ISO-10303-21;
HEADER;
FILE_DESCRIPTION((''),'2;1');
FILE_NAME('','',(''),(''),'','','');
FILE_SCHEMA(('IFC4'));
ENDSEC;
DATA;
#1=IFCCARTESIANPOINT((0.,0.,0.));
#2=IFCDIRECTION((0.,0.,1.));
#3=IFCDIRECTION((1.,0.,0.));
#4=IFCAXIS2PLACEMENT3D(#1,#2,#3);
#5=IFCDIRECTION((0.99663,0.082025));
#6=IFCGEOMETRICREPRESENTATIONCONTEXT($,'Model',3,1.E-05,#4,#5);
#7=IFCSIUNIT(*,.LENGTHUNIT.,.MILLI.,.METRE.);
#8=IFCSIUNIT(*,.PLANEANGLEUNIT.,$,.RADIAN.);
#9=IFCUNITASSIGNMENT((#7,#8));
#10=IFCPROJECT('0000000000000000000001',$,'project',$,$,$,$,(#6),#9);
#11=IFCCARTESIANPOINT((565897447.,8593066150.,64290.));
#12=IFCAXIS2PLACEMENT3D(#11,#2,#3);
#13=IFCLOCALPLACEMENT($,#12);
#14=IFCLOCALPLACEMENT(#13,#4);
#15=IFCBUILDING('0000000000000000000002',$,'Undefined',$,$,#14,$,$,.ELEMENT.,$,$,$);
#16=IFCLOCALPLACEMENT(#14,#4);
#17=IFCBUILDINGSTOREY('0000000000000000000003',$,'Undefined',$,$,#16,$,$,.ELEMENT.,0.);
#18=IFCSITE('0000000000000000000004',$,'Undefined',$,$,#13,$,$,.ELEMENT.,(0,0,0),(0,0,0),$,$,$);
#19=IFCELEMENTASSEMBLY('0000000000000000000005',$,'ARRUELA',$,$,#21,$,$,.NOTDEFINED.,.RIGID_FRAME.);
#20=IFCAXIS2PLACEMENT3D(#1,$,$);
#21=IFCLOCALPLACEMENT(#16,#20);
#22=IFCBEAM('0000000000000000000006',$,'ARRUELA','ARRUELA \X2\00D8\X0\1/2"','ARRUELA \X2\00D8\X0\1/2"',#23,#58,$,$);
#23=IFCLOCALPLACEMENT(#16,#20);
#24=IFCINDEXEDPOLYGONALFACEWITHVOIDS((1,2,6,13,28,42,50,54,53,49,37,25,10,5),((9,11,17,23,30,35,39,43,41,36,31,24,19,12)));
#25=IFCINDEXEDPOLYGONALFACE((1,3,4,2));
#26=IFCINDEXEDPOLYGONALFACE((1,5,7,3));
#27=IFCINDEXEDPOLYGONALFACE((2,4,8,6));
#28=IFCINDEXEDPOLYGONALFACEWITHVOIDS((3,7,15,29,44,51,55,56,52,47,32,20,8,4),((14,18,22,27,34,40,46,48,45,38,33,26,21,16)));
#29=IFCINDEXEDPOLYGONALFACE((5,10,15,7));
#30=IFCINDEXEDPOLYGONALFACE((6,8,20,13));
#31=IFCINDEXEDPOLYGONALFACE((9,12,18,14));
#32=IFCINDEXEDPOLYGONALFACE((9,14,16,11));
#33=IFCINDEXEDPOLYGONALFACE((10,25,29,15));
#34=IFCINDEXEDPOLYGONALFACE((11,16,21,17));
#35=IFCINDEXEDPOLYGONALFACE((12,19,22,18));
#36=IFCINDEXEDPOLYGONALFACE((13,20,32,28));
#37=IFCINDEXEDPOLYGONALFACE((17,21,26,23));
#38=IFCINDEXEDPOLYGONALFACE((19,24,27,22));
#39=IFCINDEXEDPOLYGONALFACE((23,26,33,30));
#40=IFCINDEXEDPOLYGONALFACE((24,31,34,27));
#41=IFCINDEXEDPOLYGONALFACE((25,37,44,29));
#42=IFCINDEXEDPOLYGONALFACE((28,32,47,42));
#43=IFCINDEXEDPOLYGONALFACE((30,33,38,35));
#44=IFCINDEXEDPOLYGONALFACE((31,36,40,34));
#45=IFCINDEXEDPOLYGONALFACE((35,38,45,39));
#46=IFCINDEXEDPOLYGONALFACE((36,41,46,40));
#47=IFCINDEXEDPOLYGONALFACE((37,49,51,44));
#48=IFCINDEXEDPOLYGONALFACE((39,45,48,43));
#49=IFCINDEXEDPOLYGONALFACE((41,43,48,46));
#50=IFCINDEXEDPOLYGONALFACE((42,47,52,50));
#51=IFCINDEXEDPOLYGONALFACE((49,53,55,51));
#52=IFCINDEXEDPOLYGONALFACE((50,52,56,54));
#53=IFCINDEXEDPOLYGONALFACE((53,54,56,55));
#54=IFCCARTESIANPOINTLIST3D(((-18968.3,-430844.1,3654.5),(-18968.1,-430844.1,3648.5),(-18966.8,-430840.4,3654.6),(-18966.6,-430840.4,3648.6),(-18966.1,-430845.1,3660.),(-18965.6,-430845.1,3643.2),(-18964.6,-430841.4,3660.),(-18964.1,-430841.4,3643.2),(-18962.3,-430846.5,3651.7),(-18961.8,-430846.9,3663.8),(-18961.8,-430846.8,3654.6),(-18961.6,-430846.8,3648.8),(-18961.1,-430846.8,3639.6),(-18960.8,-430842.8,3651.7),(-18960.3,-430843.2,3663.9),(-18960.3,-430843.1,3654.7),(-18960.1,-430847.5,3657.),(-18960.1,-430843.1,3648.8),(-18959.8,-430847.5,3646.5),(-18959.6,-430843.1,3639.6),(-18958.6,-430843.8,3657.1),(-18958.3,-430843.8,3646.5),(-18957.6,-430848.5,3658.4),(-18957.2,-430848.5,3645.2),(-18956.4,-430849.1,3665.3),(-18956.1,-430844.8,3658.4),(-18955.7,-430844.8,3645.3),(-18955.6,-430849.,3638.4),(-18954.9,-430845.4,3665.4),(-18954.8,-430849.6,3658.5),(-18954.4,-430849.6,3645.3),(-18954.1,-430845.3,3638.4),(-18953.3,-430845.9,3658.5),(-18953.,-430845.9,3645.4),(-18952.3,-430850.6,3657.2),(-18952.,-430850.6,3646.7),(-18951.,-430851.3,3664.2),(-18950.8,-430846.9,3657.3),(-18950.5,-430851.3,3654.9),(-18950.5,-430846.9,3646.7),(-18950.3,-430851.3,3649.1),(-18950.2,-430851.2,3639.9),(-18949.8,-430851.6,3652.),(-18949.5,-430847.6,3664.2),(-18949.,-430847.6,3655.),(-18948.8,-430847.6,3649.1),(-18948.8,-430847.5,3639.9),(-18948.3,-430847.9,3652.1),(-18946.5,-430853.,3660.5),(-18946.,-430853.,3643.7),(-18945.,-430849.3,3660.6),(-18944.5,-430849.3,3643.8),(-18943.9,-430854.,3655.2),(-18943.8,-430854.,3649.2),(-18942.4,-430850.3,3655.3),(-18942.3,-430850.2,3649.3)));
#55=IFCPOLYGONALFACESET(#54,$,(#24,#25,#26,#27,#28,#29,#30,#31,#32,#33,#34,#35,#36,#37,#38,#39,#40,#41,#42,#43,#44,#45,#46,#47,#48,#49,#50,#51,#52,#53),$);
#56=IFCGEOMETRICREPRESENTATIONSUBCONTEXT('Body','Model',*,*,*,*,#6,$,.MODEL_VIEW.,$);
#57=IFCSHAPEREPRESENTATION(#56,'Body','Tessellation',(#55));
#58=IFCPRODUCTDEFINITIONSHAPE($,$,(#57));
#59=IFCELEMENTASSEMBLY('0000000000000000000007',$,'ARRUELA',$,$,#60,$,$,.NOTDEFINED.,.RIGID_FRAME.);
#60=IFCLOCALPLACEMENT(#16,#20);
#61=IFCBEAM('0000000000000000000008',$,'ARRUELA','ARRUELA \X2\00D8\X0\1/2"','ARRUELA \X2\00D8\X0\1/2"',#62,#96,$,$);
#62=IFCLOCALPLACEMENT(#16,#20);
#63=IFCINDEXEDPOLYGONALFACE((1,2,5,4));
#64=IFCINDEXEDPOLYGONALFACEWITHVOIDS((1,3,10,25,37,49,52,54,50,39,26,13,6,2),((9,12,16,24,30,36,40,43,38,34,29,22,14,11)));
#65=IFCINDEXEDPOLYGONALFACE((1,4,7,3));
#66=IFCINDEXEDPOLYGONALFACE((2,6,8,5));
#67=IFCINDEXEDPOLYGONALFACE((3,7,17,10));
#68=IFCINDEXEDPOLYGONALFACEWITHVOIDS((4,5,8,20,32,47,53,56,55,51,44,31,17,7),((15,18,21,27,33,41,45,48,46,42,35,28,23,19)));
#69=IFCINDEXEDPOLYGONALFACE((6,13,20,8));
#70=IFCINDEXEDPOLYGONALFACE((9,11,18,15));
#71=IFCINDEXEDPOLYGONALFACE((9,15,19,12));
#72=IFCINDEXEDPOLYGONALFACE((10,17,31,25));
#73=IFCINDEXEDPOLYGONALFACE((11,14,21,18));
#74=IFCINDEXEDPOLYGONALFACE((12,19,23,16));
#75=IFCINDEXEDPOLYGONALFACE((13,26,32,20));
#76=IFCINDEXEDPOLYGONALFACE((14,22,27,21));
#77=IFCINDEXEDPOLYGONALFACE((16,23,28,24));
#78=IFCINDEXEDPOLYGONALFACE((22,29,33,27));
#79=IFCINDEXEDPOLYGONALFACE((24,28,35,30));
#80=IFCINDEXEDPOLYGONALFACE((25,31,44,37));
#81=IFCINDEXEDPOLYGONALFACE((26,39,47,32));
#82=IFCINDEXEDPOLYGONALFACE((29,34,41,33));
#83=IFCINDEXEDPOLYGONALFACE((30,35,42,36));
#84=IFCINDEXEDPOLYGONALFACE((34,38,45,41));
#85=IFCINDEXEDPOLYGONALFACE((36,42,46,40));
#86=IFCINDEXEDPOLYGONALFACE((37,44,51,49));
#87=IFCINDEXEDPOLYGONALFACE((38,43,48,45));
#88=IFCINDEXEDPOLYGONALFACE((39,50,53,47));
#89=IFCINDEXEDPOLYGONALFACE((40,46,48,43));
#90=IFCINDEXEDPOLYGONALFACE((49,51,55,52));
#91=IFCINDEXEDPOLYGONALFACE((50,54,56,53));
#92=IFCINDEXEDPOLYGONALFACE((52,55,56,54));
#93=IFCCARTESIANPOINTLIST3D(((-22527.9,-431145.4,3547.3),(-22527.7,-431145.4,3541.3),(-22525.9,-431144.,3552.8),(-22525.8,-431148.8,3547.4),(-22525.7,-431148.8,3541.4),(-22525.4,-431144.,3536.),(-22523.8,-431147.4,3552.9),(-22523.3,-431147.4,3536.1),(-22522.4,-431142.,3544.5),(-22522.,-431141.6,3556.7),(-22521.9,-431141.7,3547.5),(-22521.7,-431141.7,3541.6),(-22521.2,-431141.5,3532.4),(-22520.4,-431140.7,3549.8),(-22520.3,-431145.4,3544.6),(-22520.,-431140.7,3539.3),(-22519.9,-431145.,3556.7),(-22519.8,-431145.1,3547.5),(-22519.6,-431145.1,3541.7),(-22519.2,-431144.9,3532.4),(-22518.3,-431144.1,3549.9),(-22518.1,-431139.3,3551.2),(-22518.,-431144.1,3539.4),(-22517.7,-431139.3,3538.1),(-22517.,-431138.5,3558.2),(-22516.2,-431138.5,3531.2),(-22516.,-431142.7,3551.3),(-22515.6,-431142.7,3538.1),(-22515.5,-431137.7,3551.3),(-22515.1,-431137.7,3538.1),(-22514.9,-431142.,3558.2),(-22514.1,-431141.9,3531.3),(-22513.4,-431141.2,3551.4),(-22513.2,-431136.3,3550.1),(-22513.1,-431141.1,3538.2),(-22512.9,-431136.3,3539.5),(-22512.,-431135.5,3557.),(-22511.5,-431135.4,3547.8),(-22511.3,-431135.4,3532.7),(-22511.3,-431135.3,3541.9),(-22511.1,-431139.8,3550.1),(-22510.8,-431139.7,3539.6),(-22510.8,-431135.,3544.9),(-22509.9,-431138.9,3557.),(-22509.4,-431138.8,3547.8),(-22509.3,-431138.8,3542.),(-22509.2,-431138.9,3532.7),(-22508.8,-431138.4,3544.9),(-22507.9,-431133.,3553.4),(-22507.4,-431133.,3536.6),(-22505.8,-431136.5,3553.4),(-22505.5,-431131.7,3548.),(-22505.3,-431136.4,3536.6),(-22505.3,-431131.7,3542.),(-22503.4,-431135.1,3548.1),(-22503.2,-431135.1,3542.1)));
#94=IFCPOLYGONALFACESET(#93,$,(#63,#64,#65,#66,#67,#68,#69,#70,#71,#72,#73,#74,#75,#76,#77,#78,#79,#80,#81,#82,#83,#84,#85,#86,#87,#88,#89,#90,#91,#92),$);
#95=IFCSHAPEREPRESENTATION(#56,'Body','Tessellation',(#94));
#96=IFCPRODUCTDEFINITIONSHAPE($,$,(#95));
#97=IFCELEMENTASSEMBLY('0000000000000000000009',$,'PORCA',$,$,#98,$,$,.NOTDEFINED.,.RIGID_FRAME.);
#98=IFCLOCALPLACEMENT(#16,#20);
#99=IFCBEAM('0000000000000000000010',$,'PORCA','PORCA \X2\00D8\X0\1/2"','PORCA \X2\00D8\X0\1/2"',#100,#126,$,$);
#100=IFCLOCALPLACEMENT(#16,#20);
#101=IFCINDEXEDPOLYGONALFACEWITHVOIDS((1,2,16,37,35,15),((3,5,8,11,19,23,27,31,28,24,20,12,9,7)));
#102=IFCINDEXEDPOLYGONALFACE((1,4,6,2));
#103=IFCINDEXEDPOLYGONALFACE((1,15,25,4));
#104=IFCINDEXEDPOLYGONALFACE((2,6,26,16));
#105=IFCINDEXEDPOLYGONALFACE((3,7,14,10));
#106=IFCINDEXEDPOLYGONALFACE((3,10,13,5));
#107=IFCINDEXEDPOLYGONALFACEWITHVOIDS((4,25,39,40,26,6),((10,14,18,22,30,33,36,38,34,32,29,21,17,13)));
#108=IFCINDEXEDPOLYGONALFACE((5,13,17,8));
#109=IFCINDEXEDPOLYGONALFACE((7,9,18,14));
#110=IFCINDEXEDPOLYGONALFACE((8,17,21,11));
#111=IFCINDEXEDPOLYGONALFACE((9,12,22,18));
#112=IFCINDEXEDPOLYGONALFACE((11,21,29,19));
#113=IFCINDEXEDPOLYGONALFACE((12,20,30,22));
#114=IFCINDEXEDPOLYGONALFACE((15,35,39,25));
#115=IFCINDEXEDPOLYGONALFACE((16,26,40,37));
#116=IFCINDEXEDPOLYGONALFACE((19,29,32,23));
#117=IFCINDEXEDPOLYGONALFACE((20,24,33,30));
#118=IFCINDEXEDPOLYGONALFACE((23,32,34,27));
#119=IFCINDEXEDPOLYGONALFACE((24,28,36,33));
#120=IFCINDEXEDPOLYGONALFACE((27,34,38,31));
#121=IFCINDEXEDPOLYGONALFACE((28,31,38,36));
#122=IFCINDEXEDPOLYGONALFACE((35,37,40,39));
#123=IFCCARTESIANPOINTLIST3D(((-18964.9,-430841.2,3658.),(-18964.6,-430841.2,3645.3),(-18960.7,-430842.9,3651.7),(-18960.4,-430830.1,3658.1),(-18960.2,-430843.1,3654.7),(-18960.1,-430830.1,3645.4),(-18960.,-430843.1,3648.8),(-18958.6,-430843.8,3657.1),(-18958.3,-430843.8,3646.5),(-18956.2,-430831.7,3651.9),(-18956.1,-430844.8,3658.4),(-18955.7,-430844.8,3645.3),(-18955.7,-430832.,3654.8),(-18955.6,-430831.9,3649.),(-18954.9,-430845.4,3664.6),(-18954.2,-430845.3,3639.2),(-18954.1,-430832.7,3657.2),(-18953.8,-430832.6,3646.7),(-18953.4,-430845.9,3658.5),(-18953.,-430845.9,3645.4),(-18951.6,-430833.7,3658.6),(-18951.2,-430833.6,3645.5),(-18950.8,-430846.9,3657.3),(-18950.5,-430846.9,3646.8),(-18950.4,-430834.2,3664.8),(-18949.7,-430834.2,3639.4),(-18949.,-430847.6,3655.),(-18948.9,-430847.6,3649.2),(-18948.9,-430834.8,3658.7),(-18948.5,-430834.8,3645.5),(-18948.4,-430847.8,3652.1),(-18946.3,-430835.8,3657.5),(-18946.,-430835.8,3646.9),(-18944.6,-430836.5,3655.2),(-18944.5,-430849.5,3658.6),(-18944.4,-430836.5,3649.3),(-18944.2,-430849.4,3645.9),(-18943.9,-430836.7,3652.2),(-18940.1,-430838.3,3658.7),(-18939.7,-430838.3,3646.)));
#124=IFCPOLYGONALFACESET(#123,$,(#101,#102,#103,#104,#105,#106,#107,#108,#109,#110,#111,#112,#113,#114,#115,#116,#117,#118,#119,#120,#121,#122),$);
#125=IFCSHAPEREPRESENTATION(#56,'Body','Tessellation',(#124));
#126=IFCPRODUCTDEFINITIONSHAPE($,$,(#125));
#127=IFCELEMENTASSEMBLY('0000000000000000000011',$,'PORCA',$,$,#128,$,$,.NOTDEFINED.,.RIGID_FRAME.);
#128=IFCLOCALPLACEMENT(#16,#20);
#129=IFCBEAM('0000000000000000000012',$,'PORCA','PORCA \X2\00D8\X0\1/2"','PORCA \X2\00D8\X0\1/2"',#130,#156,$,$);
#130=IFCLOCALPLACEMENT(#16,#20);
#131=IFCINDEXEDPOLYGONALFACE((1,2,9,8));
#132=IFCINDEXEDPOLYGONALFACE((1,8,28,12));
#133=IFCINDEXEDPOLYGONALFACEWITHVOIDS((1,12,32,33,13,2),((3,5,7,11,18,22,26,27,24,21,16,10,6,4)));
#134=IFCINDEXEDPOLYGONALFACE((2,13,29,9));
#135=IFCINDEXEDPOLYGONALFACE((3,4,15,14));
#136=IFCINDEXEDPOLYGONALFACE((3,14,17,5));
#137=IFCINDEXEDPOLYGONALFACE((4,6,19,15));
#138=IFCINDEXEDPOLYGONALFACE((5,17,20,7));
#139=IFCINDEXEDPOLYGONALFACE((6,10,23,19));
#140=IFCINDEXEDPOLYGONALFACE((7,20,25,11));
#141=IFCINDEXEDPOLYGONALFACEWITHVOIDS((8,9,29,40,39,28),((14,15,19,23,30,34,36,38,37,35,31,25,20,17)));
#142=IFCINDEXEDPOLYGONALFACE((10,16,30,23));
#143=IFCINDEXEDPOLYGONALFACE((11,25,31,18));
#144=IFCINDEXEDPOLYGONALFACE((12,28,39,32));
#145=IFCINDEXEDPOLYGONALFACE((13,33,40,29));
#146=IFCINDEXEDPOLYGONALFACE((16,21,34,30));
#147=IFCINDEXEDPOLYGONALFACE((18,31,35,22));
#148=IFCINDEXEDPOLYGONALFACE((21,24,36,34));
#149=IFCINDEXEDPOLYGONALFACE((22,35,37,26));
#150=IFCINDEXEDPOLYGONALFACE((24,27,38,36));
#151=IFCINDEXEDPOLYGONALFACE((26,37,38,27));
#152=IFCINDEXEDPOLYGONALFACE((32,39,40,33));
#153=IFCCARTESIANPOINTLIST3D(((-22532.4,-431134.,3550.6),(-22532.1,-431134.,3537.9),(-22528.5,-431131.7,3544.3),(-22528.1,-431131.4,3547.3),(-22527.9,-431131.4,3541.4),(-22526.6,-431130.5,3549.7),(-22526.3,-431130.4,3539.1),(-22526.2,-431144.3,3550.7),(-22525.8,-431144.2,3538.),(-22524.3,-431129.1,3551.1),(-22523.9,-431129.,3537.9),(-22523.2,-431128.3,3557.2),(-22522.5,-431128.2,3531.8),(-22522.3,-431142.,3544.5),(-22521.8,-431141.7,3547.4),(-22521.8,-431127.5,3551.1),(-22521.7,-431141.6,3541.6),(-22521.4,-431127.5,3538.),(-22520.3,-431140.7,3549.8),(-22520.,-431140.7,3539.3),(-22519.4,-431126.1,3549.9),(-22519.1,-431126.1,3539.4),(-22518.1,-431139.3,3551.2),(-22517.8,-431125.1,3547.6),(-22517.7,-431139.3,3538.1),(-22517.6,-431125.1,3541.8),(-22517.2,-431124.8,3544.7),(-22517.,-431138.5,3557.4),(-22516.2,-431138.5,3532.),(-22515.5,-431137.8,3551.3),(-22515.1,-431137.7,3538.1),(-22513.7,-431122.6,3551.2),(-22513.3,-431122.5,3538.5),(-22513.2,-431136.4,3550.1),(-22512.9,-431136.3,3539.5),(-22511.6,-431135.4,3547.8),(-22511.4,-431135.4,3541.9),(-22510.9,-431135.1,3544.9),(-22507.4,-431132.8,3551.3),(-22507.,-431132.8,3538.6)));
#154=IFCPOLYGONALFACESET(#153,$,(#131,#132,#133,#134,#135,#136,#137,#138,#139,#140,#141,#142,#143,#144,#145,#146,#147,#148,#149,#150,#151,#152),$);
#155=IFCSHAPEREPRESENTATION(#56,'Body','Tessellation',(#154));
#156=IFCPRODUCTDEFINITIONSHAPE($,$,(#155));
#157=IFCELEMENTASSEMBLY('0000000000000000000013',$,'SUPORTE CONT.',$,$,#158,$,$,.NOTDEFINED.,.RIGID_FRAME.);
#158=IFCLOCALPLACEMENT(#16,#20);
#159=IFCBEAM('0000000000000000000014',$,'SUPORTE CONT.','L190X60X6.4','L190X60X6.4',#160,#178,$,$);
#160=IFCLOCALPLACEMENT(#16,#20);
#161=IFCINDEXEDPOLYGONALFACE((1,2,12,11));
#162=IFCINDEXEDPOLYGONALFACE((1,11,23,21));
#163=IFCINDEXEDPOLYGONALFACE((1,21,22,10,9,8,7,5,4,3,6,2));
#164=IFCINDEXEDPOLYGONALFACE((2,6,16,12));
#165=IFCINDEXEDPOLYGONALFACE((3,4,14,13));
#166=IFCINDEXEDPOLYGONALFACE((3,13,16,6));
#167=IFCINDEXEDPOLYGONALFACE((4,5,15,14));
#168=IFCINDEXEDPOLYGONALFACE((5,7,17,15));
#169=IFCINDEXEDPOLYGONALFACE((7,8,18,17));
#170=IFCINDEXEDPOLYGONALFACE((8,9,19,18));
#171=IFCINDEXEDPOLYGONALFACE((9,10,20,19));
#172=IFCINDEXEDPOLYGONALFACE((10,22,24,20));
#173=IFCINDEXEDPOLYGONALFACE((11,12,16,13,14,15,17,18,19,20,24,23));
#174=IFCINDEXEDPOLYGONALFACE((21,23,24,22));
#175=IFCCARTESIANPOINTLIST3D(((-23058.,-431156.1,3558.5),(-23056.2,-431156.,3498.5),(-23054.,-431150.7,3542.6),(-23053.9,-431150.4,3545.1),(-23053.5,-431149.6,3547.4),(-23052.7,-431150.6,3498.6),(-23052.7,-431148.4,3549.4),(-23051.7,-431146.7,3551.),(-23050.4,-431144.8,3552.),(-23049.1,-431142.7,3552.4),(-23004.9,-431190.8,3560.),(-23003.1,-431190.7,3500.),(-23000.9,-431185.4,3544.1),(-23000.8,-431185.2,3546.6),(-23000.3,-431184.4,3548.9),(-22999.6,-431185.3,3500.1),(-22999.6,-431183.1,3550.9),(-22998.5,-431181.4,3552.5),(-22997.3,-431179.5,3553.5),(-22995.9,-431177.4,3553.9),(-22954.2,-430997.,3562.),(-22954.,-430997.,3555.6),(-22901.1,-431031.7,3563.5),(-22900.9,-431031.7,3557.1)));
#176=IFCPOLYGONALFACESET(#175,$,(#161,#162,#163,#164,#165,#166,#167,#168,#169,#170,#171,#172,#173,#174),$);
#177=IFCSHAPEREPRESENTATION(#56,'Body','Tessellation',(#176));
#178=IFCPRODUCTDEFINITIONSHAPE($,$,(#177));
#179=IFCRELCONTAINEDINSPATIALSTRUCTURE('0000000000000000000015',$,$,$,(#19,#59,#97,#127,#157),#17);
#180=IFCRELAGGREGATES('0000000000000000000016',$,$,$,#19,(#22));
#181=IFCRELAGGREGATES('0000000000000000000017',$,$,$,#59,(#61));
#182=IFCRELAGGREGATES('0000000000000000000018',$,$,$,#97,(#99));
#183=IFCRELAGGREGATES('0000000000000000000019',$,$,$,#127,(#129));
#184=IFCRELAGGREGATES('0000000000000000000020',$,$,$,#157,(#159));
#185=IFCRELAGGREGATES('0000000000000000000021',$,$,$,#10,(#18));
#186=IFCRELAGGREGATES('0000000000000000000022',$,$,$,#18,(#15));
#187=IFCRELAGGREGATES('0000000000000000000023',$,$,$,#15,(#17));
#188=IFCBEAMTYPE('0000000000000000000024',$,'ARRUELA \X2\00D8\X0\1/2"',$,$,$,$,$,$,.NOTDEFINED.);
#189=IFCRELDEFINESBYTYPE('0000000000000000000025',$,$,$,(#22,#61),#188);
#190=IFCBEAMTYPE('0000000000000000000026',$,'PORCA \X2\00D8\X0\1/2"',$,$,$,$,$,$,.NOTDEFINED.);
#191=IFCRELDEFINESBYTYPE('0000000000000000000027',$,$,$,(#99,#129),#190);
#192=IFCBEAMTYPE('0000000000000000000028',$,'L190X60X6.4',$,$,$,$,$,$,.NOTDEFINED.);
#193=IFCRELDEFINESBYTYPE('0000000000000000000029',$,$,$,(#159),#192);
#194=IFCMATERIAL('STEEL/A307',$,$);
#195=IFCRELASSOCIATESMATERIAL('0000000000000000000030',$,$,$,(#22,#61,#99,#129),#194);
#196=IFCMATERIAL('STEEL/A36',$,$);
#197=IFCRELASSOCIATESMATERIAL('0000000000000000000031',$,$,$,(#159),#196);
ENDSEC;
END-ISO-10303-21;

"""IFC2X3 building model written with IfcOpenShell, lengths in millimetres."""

from ifc_helpers import new_model, si_unit, direction, frame, origin_with_axes, origin_2d_with_axis, place, context, subcontext, project, spatial, polyline, l_section, outline, extrude, material, type_object, element, aggregate, save


model = new_model("IFC2X3")

# Units and contexts
model_context = context("Model", 3, precision=1e-05, world=origin_with_axes(), true_north=direction((0.99663, 0.082025)))
body_context = subcontext(model_context, "Body", "Model", "MODEL_VIEW")
ifc_project = project(units=[si_unit("LENGTHUNIT", "METRE", prefix="MILLI"), si_unit("PLANEANGLEUNIT", "RADIAN")], contexts=[model_context])

# Site, building, storey
site_placement = place(None, frame((565897447.0, 8593066150.0, 64290.0), z_axis=(0.0, 0.0, 1.0), x_axis=(1.0, 0.0, 0.0)))
site = spatial("IfcSite", under=ifc_project, at=site_placement, Name="Undefined", CompositionType="ELEMENT", RefLatitude=(0, 0, 0), RefLongitude=(0, 0, 0))
building_placement = place(site_placement, origin_with_axes())
building = spatial("IfcBuilding", under=site, at=building_placement, Name="Undefined", CompositionType="ELEMENT")
storey_placement = place(building_placement, origin_with_axes())
storey = spatial("IfcBuildingStorey", under=building, at=storey_placement, Name="Undefined", CompositionType="ELEMENT", Elevation=0.0)

# Element assemblies, beams
assembly_1_placement = place(storey_placement, origin_with_axes())
assembly_1 = element("IfcElementAssembly", 1, at=assembly_1_placement, inside=storey, Name="ARRUELA", AssemblyPlace="NOTDEFINED", PredefinedType="RIGID_FRAME")
ifc_material_1 = material(Name="STEEL/A307")
beam_type_1 = type_object("IfcBeamType", Name="ARRUELA Ø1/2\"", PredefinedType="NOTDEFINED")
beam_1_placement = place(assembly_1_placement, frame((-18954.5, -430845.3, 3651.9), z_axis=(0.92709, -0.373879, 0.026799), x_axis=(-0.373645, -0.927474, -0.013454)))
beam_1 = element("IfcBeam", 2, at=beam_1_placement, type_object=beam_type_1, material=ifc_material_1, Name="ARRUELA", Description="ARRUELA Ø1/2\"", ObjectType="ARRUELA Ø1/2\"", context=body_context, shape_type="SweptSolid", body=[
    extrude(outline(polyline([(-12.2, 5.9), (-8.4, 10.5), (-3.0, 13.2), (3.0, 13.2), (8.4, 10.5), (12.2, 5.9), (13.5, 0.0), (12.2, -5.9), (8.4, -10.5), (3.0, -13.2), (-3.0, -13.2), (-8.4, -10.5), (-12.2, -5.9), (-13.5, 0.0), (-12.2, 5.9)]), holes=[polyline([(5.3, 4.2), (2.9, 6.1), (0.0, 6.8), (-2.9, 6.1), (-5.3, 4.2), (-6.6, 1.5), (-6.6, -1.5), (-5.3, -4.2), (-2.9, -6.1), (0.0, -6.7), (2.9, -6.1), (5.3, -4.2), (6.6, -1.5), (6.6, 1.5), (5.3, 4.2)])]), frame((4.0, 0.0, 0.0), z_axis=(-1.0, 0.0, 0.0), x_axis=(0.0, -1.0, 0.0)), (0.0, 0.0, 1.0), 4.0),
])
aggregate(assembly_1, [beam_1])
assembly_2_placement = place(storey_placement, origin_with_axes())
assembly_2 = element("IfcElementAssembly", 3, at=assembly_2_placement, inside=storey, Name="ARRUELA", AssemblyPlace="NOTDEFINED", PredefinedType="RIGID_FRAME")
beam_2_placement = place(assembly_2_placement, frame((-22516.6, -431138.5, 3544.7), z_axis=(0.853486, 0.520426, 0.026799), x_axis=(0.520257, -0.853903, 0.013454)))
beam_2 = element("IfcBeam", 4, at=beam_2_placement, type_object=beam_type_1, material=ifc_material_1, Name="ARRUELA", Description="ARRUELA Ø1/2\"", ObjectType="ARRUELA Ø1/2\"", context=body_context, shape_type="SweptSolid", body=[
    extrude(outline(polyline([(-12.2, 5.9), (-8.4, 10.5), (-3.0, 13.2), (3.0, 13.2), (8.4, 10.5), (12.2, 5.9), (13.5, 0.0), (12.2, -5.9), (8.4, -10.5), (3.0, -13.2), (-3.0, -13.2), (-8.4, -10.5), (-12.2, -5.9), (-13.5, 0.0), (-12.2, 5.9)]), holes=[polyline([(5.3, 4.2), (2.9, 6.1), (0.0, 6.8), (-2.9, 6.1), (-5.3, 4.2), (-6.6, 1.5), (-6.6, -1.5), (-5.3, -4.2), (-2.9, -6.1), (0.0, -6.7), (2.9, -6.1), (5.3, -4.2), (6.6, -1.5), (6.6, 1.5), (5.3, 4.2)])]), frame((4.0, 0.0, 0.0), z_axis=(-1.0, 0.0, 0.0), x_axis=(0.0, -1.0, 0.0)), (0.0, 0.0, 1.0), 4.0),
])
aggregate(assembly_2, [beam_2])
assembly_3_placement = place(storey_placement, origin_with_axes())
assembly_3 = element("IfcElementAssembly", 5, at=assembly_3_placement, inside=storey, Name="PORCA", AssemblyPlace="NOTDEFINED", PredefinedType="RIGID_FRAME")
beam_type_2 = type_object("IfcBeamType", Name="PORCA Ø1/2\"", PredefinedType="NOTDEFINED")
beam_3_placement = place(assembly_3_placement, frame((-18950.1, -430834.2, 3652.1), z_axis=(0.92709, -0.373879, 0.026799), x_axis=(-0.373645, -0.927474, -0.013454)))
beam_3 = element("IfcBeam", 6, at=beam_3_placement, type_object=beam_type_2, material=ifc_material_1, Name="PORCA", Description="PORCA Ø1/2\"", ObjectType="PORCA Ø1/2\"", context=body_context, shape_type="SweptSolid", body=[
    extrude(outline(polyline([(-6.3, -11.0), (-12.7, 0.0), (-6.3, 11.0), (6.3, 11.0), (12.7, 0.0), (6.3, -11.0), (-6.3, -11.0)]), holes=[polyline([(5.3, 4.2), (2.9, 6.0), (0.0, 6.7), (-2.9, 6.0), (-5.3, 4.2), (-6.6, 1.5), (-6.6, -1.5), (-5.3, -4.2), (-2.9, -6.0), (0.0, -6.7), (2.9, -6.0), (5.3, -4.2), (6.6, -1.5), (6.6, 1.5), (5.3, 4.2)])]), frame((12.0, 0.0, 0.0), z_axis=(-1.0, 0.0, 0.0), x_axis=(0.0, -1.0, 0.0)), (0.0, 0.0, 1.0), 12.0),
])
aggregate(assembly_3, [beam_3])
assembly_4_placement = place(storey_placement, origin_with_axes())
assembly_4 = element("IfcElementAssembly", 7, at=assembly_4_placement, inside=storey, Name="PORCA", AssemblyPlace="NOTDEFINED", PredefinedType="RIGID_FRAME")
beam_4_placement = place(assembly_4_placement, frame((-22522.9, -431128.3, 3544.5), z_axis=(0.853486, 0.520426, 0.026799), x_axis=(0.520257, -0.853903, 0.013454)))
beam_4 = element("IfcBeam", 8, at=beam_4_placement, type_object=beam_type_2, material=ifc_material_1, Name="PORCA", Description="PORCA Ø1/2\"", ObjectType="PORCA Ø1/2\"", context=body_context, shape_type="SweptSolid", body=[
    extrude(outline(polyline([(-6.3, -11.0), (-12.7, 0.0), (-6.3, 11.0), (6.3, 11.0), (12.7, 0.0), (6.3, -11.0), (-6.3, -11.0)]), holes=[polyline([(5.3, 4.2), (2.9, 6.0), (0.0, 6.7), (-2.9, 6.0), (-5.3, 4.2), (-6.6, 1.5), (-6.6, -1.5), (-5.3, -4.2), (-2.9, -6.0), (0.0, -6.7), (2.9, -6.0), (5.3, -4.2), (6.6, -1.5), (6.6, 1.5), (5.3, 4.2)])]), frame((12.0, 0.0, 0.0), z_axis=(-1.0, 0.0, 0.0), x_axis=(0.0, -1.0, 0.0)), (0.0, 0.0, 1.0), 12.0),
])
aggregate(assembly_4, [beam_4])
assembly_5_placement = place(storey_placement, origin_with_axes())
assembly_5 = element("IfcElementAssembly", 9, at=assembly_5_placement, inside=storey, Name="SUPORTE CONT.", AssemblyPlace="NOTDEFINED", PredefinedType="RIGID_FRAME")
ifc_material_2 = material(Name="STEEL/A36")
beam_type_3 = type_object("IfcBeamType", Name="L190X60X6.4", PredefinedType="NOTDEFINED")
beam_5_placement = place(assembly_5_placement, frame((-22952.1, -431111.2, 3531.7), z_axis=(0.546411, 0.837315, 0.018398), x_axis=(-0.836984, 0.546715, -0.02368)))
beam_5 = element("IfcBeam", 10, at=beam_5_placement, type_object=beam_type_3, material=ifc_material_2, Name="SUPORTE CONT.", Description="L190X60X6.4", ObjectType="L190X60X6.4", context=body_context, shape_type="SweptSolid", body=[
    extrude(l_section(Depth=190.0, Width=60.0, Thickness=6.4, FilletRadius=9.6, at=origin_2d_with_axis()), frame((63.5, 0.0, 0.0), z_axis=(-1.0, 0.0, 0.0), x_axis=(0.0, -1.0, 0.0)), (0.0, 0.0, 1.0), 63.5),
])

aggregate(assembly_5, [beam_5])

save(model, "model.ifc")
